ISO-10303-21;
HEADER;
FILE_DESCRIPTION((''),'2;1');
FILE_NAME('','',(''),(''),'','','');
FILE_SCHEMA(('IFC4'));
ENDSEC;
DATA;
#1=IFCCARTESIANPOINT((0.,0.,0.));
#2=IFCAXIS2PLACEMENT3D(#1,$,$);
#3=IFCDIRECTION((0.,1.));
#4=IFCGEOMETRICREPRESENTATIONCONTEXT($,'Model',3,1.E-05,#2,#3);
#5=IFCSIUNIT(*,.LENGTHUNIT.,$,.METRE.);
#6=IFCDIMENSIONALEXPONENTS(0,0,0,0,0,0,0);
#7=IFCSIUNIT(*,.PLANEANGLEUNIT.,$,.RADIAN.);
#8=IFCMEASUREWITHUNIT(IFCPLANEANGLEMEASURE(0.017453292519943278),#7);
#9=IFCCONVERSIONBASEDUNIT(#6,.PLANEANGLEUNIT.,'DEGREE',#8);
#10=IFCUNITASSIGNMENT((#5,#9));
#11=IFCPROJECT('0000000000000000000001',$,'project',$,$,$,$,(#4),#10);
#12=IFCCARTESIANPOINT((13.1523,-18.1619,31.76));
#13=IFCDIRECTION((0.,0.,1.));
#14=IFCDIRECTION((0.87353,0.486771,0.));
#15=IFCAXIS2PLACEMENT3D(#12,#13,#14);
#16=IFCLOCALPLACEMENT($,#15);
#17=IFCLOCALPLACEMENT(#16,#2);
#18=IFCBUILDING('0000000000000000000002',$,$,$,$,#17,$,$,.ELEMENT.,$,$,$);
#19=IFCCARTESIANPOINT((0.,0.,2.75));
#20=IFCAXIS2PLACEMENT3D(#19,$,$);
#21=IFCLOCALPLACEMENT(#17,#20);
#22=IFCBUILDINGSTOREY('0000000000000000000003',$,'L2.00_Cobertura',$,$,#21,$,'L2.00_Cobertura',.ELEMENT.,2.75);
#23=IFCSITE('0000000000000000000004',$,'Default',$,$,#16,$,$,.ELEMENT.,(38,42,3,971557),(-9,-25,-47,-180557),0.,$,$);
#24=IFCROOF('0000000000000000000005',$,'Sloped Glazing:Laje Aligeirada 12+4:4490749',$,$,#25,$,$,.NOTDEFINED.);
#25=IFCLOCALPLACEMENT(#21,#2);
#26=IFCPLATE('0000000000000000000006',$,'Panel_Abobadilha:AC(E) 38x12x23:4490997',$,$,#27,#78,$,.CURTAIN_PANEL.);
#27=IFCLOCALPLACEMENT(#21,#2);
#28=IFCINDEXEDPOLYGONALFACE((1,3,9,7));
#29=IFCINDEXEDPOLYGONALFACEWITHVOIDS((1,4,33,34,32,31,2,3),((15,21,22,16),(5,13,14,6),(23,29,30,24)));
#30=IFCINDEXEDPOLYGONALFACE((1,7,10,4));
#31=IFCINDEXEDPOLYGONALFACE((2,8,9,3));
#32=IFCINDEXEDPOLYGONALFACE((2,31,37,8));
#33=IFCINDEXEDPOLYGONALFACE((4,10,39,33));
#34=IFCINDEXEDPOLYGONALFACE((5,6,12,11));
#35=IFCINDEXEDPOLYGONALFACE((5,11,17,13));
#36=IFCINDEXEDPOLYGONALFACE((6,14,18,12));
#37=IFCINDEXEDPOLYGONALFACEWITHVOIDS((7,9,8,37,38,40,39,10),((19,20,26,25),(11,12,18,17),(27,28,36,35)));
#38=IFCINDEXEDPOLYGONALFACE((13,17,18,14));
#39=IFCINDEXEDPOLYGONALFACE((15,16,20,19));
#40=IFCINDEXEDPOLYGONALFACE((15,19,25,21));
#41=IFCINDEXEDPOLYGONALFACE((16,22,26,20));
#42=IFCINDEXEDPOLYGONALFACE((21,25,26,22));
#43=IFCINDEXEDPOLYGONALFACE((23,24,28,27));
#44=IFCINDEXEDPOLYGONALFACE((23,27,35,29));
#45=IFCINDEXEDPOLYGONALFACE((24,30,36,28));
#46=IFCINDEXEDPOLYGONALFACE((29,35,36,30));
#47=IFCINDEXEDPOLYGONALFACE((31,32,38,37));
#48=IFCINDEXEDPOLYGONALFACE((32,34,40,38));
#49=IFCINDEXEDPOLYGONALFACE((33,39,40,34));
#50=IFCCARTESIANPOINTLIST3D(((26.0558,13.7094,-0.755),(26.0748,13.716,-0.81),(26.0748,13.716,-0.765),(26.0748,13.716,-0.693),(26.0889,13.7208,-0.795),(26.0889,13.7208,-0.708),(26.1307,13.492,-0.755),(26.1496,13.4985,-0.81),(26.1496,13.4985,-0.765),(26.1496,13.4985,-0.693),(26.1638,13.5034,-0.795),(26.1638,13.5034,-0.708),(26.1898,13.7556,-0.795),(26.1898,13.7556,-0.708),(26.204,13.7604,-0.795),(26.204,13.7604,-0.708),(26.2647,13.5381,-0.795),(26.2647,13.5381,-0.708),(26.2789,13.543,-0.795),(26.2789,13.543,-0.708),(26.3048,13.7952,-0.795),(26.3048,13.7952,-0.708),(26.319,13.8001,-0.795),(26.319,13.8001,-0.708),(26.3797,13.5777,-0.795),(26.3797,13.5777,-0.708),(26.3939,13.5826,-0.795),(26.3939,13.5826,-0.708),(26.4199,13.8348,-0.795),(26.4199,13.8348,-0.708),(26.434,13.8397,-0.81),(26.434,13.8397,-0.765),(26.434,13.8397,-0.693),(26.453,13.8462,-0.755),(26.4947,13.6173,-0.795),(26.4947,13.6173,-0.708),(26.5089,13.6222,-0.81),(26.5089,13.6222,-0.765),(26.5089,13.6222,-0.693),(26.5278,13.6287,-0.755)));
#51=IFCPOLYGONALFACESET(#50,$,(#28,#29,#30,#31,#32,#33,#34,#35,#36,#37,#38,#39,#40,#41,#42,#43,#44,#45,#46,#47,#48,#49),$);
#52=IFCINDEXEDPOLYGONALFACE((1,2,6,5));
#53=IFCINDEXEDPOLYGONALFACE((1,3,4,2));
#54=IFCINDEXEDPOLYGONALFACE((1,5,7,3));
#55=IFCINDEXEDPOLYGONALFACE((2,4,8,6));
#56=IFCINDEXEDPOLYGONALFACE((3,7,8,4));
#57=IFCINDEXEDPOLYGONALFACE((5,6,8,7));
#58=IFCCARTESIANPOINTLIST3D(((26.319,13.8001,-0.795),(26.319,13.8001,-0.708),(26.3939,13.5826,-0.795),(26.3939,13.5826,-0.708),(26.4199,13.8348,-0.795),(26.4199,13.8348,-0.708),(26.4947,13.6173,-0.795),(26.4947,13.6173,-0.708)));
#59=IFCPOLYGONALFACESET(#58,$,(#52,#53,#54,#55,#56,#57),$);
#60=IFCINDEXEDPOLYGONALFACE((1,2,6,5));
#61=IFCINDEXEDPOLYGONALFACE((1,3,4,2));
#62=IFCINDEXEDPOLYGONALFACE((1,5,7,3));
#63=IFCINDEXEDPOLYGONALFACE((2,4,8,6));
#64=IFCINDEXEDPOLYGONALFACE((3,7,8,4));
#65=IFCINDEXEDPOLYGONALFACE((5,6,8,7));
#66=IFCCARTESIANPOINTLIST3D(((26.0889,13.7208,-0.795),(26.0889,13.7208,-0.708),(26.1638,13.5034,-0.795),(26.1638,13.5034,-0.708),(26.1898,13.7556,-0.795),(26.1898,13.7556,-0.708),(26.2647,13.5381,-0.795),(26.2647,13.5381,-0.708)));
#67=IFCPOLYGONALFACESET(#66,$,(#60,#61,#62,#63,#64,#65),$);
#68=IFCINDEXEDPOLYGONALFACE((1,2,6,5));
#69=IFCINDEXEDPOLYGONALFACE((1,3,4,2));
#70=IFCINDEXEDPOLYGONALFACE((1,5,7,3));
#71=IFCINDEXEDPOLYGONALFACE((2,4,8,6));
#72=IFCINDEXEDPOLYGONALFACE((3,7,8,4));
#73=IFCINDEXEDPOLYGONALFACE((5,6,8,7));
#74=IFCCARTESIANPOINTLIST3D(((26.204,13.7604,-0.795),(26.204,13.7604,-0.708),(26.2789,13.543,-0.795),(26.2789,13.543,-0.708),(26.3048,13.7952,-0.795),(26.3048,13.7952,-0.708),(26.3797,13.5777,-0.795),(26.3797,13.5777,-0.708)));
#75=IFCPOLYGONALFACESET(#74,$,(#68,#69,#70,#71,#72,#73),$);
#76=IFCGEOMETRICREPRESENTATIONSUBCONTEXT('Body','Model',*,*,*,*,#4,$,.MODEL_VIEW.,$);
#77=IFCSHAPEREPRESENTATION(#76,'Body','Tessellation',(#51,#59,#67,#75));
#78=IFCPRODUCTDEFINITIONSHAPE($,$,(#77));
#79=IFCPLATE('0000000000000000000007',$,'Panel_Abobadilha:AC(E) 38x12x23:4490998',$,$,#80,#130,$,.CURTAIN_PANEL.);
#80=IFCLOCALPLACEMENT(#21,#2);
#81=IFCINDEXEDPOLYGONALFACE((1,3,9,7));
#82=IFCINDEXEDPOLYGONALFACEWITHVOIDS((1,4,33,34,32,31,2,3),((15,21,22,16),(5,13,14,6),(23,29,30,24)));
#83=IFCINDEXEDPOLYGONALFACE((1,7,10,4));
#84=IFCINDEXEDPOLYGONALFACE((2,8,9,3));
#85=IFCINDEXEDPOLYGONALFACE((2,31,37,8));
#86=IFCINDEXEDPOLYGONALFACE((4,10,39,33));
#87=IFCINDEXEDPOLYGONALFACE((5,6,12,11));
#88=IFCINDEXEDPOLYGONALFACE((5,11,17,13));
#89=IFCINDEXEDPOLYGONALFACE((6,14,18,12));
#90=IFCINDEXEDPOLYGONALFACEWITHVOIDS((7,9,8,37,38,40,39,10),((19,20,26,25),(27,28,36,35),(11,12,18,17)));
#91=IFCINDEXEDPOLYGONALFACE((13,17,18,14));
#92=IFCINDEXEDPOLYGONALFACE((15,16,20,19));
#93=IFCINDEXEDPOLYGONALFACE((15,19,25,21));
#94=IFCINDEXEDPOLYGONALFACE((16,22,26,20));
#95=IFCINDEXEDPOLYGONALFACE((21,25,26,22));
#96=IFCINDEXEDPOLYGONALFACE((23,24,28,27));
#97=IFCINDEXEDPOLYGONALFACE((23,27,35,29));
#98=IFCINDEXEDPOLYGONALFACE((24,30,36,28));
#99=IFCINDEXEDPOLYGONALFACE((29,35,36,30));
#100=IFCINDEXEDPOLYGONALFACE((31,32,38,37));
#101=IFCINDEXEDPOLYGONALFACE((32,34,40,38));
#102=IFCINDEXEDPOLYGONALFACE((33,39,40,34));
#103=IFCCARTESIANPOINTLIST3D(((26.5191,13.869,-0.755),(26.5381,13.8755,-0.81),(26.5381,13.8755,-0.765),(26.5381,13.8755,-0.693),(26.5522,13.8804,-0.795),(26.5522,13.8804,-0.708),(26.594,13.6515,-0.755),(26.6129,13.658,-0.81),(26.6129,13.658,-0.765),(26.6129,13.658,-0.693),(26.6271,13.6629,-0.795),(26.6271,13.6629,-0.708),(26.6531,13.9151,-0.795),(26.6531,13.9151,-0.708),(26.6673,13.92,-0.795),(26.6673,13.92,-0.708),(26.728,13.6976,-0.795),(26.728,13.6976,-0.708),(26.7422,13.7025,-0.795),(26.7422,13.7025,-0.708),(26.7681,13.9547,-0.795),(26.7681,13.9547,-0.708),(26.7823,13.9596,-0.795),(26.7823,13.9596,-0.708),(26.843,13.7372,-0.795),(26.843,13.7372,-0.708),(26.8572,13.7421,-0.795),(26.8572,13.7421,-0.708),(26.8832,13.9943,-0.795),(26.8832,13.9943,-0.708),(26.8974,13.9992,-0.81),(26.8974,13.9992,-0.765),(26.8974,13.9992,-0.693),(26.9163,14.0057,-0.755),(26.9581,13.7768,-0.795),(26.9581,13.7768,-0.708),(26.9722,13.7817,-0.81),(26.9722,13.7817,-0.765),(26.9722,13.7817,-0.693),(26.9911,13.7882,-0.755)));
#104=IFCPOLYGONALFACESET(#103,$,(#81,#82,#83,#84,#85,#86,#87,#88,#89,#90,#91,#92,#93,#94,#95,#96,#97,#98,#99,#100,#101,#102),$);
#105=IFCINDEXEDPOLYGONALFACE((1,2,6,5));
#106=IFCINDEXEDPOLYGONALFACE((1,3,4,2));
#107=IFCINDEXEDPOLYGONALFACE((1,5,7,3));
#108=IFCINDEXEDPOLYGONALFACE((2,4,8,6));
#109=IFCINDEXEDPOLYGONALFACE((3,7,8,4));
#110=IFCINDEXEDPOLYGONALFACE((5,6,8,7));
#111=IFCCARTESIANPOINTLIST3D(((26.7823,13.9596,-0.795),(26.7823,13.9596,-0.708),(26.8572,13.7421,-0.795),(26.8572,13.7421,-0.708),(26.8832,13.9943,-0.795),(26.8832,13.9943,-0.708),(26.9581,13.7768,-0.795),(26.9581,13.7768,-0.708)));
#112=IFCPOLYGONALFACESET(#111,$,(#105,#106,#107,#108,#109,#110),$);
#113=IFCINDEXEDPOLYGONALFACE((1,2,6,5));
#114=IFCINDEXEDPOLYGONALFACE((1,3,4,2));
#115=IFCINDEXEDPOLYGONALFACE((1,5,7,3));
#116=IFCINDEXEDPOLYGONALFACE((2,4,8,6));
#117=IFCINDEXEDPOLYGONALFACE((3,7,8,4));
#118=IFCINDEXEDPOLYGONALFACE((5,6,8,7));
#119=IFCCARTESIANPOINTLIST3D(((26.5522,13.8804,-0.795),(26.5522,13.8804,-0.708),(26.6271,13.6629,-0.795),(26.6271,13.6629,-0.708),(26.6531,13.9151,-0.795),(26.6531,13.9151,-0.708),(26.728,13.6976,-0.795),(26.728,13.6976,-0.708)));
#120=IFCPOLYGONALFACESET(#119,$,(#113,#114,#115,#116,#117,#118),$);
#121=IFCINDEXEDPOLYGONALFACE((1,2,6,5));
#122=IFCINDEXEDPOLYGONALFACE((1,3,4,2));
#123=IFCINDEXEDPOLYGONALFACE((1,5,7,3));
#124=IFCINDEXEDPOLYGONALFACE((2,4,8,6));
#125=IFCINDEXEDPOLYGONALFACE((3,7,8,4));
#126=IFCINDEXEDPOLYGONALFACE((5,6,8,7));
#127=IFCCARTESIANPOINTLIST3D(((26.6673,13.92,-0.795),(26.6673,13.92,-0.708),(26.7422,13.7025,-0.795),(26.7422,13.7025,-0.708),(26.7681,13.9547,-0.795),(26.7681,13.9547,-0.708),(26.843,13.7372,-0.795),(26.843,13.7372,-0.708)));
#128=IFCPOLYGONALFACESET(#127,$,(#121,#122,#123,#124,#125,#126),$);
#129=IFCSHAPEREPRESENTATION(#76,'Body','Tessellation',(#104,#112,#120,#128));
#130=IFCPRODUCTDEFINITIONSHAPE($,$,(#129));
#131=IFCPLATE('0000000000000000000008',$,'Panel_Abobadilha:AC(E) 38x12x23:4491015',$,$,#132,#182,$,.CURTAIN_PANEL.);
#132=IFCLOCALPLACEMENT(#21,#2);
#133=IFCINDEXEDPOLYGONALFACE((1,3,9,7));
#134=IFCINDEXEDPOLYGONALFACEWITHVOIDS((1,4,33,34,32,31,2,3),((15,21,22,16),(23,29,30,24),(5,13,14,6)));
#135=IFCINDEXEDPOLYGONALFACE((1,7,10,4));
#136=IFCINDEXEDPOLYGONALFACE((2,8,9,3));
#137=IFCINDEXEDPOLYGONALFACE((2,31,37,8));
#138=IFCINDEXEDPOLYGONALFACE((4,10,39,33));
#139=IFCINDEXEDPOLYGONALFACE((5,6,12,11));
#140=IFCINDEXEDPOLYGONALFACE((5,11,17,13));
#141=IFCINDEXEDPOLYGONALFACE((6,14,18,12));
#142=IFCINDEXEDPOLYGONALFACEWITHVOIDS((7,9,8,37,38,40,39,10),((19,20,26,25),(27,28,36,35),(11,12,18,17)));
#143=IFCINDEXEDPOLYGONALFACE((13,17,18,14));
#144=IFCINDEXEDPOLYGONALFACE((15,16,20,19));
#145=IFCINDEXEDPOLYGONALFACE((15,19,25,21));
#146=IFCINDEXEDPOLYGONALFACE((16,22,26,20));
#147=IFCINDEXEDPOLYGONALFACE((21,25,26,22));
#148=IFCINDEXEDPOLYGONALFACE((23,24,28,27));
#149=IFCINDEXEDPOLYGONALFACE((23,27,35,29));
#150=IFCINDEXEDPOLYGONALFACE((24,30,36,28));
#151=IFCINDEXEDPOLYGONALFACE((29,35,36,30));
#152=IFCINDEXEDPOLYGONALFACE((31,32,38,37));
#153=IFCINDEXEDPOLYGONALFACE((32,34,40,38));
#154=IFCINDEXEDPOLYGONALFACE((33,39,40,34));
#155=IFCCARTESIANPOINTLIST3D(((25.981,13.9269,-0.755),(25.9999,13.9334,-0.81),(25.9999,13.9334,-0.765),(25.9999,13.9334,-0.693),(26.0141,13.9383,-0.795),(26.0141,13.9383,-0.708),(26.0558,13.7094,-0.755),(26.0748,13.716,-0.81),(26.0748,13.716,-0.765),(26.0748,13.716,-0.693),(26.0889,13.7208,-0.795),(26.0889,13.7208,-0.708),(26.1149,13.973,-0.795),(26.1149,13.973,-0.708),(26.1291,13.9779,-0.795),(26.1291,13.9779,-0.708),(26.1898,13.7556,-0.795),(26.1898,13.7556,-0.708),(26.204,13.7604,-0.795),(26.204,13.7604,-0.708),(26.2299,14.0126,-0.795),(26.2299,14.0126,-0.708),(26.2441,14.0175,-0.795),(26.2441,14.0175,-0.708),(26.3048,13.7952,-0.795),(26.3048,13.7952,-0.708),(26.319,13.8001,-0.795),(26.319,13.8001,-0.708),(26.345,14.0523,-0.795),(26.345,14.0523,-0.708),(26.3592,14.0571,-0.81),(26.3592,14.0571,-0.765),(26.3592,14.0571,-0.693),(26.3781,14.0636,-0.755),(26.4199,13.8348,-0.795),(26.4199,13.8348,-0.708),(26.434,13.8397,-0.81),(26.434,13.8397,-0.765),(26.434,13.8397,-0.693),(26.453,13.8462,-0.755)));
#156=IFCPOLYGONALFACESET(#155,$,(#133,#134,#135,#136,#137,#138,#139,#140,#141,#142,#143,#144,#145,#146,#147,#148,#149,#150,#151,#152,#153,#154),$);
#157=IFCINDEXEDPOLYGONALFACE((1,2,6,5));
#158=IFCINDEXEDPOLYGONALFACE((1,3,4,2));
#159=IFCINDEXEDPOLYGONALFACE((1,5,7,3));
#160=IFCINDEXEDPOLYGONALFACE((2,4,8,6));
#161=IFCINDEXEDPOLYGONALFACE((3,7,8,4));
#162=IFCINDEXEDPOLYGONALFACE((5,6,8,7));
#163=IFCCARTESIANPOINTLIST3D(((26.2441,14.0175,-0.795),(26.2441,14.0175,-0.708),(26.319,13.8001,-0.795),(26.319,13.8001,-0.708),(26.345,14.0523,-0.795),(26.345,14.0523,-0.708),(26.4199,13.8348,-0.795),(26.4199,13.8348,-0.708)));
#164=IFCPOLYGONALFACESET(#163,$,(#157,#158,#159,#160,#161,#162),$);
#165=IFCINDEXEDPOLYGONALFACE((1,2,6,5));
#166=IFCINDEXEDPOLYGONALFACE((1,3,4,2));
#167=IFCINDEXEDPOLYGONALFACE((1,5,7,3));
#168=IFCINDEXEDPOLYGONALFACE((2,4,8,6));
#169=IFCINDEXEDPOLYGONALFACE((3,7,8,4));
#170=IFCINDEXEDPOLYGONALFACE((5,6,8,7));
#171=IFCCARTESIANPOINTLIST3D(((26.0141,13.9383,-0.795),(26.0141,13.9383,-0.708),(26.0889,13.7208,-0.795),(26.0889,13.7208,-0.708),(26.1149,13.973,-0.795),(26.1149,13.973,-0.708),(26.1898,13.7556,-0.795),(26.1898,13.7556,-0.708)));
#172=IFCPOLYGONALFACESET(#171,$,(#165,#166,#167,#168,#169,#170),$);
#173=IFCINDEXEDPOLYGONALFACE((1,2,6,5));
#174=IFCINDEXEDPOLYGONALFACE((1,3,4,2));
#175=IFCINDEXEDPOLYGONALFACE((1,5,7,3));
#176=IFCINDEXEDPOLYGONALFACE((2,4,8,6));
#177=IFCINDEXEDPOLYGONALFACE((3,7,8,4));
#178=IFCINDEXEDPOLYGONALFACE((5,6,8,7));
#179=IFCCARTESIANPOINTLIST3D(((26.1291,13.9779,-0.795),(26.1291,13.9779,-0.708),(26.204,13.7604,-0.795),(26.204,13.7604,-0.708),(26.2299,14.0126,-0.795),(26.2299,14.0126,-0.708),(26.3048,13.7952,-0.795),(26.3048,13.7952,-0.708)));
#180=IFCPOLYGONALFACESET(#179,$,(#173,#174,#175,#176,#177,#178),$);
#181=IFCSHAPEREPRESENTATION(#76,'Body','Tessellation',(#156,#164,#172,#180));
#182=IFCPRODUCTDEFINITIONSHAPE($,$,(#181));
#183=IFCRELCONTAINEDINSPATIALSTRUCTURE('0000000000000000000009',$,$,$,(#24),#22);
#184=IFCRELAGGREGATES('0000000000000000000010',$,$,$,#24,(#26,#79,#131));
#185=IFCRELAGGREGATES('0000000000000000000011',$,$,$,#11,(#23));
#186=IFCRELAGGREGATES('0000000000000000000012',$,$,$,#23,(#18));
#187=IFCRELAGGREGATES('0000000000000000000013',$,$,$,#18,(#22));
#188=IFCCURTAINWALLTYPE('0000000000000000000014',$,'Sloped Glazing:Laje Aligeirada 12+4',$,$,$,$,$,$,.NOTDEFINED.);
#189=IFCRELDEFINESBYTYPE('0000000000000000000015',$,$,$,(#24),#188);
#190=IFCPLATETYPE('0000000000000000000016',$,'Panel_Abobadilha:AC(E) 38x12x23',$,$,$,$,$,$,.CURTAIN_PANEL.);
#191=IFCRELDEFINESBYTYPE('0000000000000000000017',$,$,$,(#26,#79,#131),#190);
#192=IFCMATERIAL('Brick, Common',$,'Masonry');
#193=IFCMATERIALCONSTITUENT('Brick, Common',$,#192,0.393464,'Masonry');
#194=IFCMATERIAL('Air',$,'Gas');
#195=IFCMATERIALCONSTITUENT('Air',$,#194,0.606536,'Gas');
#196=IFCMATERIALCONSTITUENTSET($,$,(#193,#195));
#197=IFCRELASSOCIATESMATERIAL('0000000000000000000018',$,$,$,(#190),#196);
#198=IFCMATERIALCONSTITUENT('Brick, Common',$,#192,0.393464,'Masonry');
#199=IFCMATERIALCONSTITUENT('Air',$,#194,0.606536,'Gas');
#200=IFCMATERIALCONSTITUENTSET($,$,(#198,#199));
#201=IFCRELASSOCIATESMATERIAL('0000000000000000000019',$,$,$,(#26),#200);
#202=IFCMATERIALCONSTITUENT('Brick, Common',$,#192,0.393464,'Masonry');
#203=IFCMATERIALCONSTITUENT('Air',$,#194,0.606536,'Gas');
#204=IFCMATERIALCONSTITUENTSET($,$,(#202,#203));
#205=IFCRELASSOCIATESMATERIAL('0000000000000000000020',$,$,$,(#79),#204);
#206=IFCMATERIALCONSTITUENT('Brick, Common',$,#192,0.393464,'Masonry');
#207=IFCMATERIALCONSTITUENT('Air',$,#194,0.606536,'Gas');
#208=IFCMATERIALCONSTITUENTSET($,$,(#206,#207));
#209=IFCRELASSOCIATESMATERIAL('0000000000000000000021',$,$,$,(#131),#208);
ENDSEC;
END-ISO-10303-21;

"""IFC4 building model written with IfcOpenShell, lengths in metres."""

from ifc_helpers import new_model, entity, si_unit, converted_unit, direction, frame, origin, place, context, subcontext, project, spatial, indexed_curve, outline, extrude, source, transform, mapped, material, constituent, constituent_set, type_object, type_shapes, element, aggregate, save


model = new_model("IFC4")

# Units and contexts
model_context = context("Model", 3, precision=1e-05, world=origin(), true_north=direction((0.0, 1.0)))
body_context = subcontext(model_context, "Body", "Model", "MODEL_VIEW")
ifc_project = project(units=[si_unit("LENGTHUNIT", "METRE"), converted_unit("PLANEANGLEUNIT", "DEGREE", entity("IfcPlaneAngleMeasure", 0.017453292519943278), si_unit("PLANEANGLEUNIT", "RADIAN"), dimensions=[0, 0, 0, 0, 0, 0, 0])], contexts=[model_context])

# Site, building, storey
site_placement = place(None, frame((13.1523, -18.1619, 31.76), z_axis=(0.0, 0.0, 1.0), x_axis=(0.87353, 0.486771, 0.0)))
site = spatial("IfcSite", under=ifc_project, at=site_placement, Name="Default", CompositionType="ELEMENT", RefLatitude=(38, 42, 3, 971557), RefLongitude=(-9, -25, -47, -180557), RefElevation=0.0)
building_placement = place(site_placement, origin())
building = spatial("IfcBuilding", under=site, at=building_placement, CompositionType="ELEMENT")
storey_placement = place(building_placement, frame((0.0, 0.0, 2.75)))
storey = spatial("IfcBuildingStorey", under=building, at=storey_placement, Name="L2.00_Cobertura", LongName="L2.00_Cobertura", CompositionType="ELEMENT", Elevation=2.75)

# Roof, plates
curtain_wall_type = type_object("IfcCurtainWallType", Name="Sloped Glazing:Laje Aligeirada 12+4", PredefinedType="NOTDEFINED")
roof_placement = place(storey_placement, frame((0.0, 0.0, -2.75)))
roof = element("IfcRoof", 1, at=roof_placement, inside=storey, type_object=curtain_wall_type, Name="Sloped Glazing:Laje Aligeirada 12+4:4490749", PredefinedType="NOTDEFINED")
ifc_material_1 = material(Name="Brick, Common", Category="Masonry")
ifc_constituent_1 = constituent(ifc_material_1, Name="Brick, Common", Category="Masonry", fraction=0.393464)
ifc_material_2 = material(Name="Air", Category="Gas")
ifc_constituent_2 = constituent(ifc_material_2, Name="Air", Category="Gas", fraction=0.606536)
ifc_constituent_set_1 = constituent_set(constituents=[ifc_constituent_1, ifc_constituent_2])
ifc_constituent_3 = constituent(ifc_material_1, Name="Brick, Common", Category="Masonry", fraction=0.393464)
ifc_constituent_4 = constituent(ifc_material_2, Name="Air", Category="Gas", fraction=0.606536)
ifc_constituent_set_2 = constituent_set(constituents=[ifc_constituent_3, ifc_constituent_4])
plate_type = type_object("IfcPlateType", Name="Panel_Abobadilha:AC(E) 38x12x23", PredefinedType="CURTAIN_PANEL", material=ifc_constituent_set_2)
shared_shape_1 = source(origin(), body_context, "Body", "SweptSolid", [
    extrude(outline(indexed_curve([(-0.19, -0.0543), (0.19, -0.0543), (0.19, -0.0093), (0.21, 0.0007), (0.19, 0.0628), (-0.19, 0.0628), (-0.21, 0.0007), (-0.19, -0.0093), (-0.19, -0.0543)], self_intersect=False), holes=[indexed_curve([(-0.0683, 0.0477), (-0.0683, -0.0393), (-0.175, -0.0393), (-0.175, 0.0477), (-0.0683, 0.0477)], self_intersect=False), indexed_curve([(0.0533, 0.0477), (0.0533, -0.0393), (-0.0533, -0.0393), (-0.0533, 0.0477), (0.0533, 0.0477)], self_intersect=False), indexed_curve([(0.175, 0.0477), (0.175, -0.0393), (0.0683, -0.0393), (0.0683, 0.0477), (0.175, 0.0477)], self_intersect=False)]), frame((0.0, 0.0543, 0.0)), (0.0, 0.0, 1.0), 0.23),
    extrude(outline(indexed_curve([(-0.0533, -0.0435), (0.0533, -0.0435), (0.0533, 0.0435), (-0.0533, 0.0435), (-0.0533, -0.0435)], self_intersect=False)), frame((0.1217, 0.0585, 0.0), z_axis=(0.0, 0.0, 1.0), x_axis=(-1.0, 0.0, 0.0)), (0.0, 0.0, 1.0), 0.23),
    extrude(outline(indexed_curve([(-0.0533, -0.0435), (0.0533, -0.0435), (0.0533, 0.0435), (-0.0533, 0.0435), (-0.0533, -0.0435)], self_intersect=False)), frame((-0.1217, 0.0585, 0.0), z_axis=(0.0, 0.0, 1.0), x_axis=(-1.0, 0.0, 0.0)), (0.0, 0.0, 1.0), 0.23),
    extrude(outline(indexed_curve([(-0.0533, -0.0435), (0.0533, -0.0435), (0.0533, 0.0435), (-0.0533, 0.0435), (-0.0533, -0.0435)], self_intersect=False)), frame((0.0, 0.0585, 0.0), z_axis=(0.0, 0.0, 1.0), x_axis=(-1.0, 0.0, 0.0)), (0.0, 0.0, 1.0), 0.23),
])
type_shapes(plate_type, [shared_shape_1])
plate_1_placement = place(roof_placement, frame((26.2544, 13.7778, 1.94), z_axis=(0.325568, -0.945519, 0.0), x_axis=(0.945519, 0.325568, 0.0)))
plate_1 = element("IfcPlate", 2, at=plate_1_placement, type_object=plate_type, material=ifc_constituent_set_1, Name="Panel_Abobadilha:AC(E) 38x12x23:4490997", PredefinedType="CURTAIN_PANEL", context=body_context, shape_type="MappedRepresentation", body=[
    mapped(shared_shape_1, transform((0.0, 0.0, 0.0), scale=1.0)),
])
ifc_constituent_5 = constituent(ifc_material_1, Name="Brick, Common", Category="Masonry", fraction=0.393464)
ifc_constituent_6 = constituent(ifc_material_2, Name="Air", Category="Gas", fraction=0.606536)
ifc_constituent_set_3 = constituent_set(constituents=[ifc_constituent_5, ifc_constituent_6])
plate_2_placement = place(roof_placement, frame((26.7177, 13.9373, 1.94), z_axis=(0.325568, -0.945519, 0.0), x_axis=(0.945519, 0.325568, 0.0)))
plate_2 = element("IfcPlate", 3, at=plate_2_placement, type_object=plate_type, material=ifc_constituent_set_3, Name="Panel_Abobadilha:AC(E) 38x12x23:4490998", PredefinedType="CURTAIN_PANEL", context=body_context, shape_type="MappedRepresentation", body=[
    mapped(shared_shape_1, transform((0.0, 0.0, 0.0), scale=1.0)),
])
ifc_constituent_7 = constituent(ifc_material_1, Name="Brick, Common", Category="Masonry", fraction=0.393464)
ifc_constituent_8 = constituent(ifc_material_2, Name="Air", Category="Gas", fraction=0.606536)
ifc_constituent_set_4 = constituent_set(constituents=[ifc_constituent_7, ifc_constituent_8])
plate_3_placement = place(roof_placement, frame((26.1795, 13.9953, 1.94), z_axis=(0.325568, -0.945519, 0.0), x_axis=(0.945519, 0.325568, 0.0)))
plate_3 = element("IfcPlate", 4, at=plate_3_placement, type_object=plate_type, material=ifc_constituent_set_4, Name="Panel_Abobadilha:AC(E) 38x12x23:4491015", PredefinedType="CURTAIN_PANEL", context=body_context, shape_type="MappedRepresentation", body=[
    mapped(shared_shape_1, transform((0.0, 0.0, 0.0), scale=1.0)),
])
aggregate(roof, [plate_1, plate_2, plate_3])

save(model, "model.ifc")
